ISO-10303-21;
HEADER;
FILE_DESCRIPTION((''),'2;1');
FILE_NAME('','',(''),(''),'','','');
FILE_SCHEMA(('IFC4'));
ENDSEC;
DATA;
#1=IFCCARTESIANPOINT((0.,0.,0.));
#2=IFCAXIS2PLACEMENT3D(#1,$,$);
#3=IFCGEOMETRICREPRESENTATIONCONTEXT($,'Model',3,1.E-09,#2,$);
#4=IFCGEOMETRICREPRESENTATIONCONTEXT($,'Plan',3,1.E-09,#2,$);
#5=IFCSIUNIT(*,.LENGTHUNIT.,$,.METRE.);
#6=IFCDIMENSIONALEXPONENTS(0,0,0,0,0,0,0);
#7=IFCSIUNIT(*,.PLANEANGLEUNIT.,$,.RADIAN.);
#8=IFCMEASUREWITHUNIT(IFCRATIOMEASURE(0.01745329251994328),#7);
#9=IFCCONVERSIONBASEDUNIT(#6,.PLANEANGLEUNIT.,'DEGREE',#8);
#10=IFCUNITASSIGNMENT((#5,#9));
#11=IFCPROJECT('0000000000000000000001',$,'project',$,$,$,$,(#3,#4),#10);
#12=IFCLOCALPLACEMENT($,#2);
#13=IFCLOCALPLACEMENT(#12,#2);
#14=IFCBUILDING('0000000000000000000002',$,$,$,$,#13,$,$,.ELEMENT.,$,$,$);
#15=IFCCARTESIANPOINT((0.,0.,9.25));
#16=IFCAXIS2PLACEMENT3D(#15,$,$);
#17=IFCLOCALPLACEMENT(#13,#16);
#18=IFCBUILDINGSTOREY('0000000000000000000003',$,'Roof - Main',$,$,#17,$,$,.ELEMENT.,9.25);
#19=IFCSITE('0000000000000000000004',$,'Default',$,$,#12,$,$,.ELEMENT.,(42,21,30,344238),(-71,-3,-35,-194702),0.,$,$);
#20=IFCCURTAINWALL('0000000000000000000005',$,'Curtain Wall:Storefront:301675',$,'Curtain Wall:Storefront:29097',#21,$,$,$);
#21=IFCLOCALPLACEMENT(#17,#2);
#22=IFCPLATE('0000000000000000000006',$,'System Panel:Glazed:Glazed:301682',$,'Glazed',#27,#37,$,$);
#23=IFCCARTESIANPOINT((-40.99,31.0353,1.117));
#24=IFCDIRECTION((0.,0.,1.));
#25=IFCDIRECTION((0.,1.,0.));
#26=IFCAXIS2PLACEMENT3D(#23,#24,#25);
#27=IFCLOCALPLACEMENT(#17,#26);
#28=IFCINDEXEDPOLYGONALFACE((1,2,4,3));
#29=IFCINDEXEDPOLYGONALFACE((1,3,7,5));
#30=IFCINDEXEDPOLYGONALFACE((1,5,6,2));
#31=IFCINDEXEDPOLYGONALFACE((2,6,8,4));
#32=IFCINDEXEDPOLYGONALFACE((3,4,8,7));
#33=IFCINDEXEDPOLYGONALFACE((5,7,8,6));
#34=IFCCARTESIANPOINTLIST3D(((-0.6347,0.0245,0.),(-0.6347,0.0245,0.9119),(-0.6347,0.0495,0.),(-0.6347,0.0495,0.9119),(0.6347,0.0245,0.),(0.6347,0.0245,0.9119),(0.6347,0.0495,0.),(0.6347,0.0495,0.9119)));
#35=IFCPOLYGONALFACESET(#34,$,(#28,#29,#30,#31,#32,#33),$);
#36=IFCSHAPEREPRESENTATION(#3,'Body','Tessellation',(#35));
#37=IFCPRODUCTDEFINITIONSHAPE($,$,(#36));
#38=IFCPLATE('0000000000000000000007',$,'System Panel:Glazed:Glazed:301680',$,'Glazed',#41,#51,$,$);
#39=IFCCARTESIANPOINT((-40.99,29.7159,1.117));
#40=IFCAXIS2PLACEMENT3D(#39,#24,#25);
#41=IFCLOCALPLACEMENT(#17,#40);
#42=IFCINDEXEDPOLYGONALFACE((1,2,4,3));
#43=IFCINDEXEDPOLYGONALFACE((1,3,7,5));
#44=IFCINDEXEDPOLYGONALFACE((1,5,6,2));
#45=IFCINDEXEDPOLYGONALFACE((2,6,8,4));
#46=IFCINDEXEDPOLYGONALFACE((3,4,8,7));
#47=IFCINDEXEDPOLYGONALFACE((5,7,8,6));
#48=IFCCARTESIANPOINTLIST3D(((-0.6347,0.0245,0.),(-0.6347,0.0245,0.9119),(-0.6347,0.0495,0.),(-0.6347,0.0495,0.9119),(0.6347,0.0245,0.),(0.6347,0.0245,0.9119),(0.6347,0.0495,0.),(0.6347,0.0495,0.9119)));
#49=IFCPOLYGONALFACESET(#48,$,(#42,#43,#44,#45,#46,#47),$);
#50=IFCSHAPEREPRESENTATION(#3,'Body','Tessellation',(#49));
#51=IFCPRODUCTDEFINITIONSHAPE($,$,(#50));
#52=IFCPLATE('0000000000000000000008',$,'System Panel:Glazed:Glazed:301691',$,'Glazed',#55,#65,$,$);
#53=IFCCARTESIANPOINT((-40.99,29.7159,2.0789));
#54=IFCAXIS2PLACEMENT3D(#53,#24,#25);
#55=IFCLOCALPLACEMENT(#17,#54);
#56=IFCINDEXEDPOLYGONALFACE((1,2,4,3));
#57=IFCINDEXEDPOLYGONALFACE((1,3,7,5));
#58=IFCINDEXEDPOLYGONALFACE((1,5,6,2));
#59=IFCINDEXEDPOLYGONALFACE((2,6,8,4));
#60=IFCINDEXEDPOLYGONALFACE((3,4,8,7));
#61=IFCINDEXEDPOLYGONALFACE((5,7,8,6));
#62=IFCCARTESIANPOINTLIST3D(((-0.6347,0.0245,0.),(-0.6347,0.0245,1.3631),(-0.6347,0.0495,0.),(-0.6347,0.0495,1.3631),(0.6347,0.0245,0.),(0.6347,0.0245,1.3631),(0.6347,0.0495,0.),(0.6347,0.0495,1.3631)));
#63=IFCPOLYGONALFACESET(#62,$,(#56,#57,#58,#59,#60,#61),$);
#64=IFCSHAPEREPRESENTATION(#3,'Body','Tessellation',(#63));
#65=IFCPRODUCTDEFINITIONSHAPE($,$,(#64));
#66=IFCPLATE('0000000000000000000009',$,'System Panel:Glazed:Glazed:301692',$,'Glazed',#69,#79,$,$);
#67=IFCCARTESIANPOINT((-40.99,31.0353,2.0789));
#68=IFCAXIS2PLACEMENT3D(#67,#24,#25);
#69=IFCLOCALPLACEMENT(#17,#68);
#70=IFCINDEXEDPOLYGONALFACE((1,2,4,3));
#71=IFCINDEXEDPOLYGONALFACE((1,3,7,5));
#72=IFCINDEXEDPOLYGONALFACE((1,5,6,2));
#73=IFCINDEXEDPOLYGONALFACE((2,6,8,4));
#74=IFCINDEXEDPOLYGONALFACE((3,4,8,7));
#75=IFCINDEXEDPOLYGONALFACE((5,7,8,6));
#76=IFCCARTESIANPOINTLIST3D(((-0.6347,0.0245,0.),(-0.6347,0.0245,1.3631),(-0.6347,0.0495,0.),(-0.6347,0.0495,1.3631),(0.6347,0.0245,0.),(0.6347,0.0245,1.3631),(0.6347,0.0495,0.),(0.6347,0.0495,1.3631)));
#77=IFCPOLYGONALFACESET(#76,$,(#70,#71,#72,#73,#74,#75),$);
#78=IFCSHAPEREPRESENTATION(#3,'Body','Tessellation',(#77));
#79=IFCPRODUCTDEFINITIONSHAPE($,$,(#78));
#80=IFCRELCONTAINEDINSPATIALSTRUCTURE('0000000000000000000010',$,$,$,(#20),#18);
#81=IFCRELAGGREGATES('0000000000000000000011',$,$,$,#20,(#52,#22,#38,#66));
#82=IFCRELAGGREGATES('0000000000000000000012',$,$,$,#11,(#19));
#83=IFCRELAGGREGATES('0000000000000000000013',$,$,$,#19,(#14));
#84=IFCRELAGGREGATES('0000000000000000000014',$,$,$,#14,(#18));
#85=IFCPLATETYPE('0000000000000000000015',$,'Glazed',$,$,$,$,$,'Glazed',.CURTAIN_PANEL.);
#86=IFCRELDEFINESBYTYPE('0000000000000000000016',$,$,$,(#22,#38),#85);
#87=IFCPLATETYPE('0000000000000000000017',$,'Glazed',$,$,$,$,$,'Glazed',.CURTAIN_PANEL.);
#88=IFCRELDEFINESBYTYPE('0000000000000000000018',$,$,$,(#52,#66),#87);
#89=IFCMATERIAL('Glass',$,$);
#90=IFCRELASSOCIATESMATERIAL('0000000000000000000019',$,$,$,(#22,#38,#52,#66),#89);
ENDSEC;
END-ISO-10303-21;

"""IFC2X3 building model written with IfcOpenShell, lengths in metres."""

from ifc_helpers import new_model, entity, si_unit, converted_unit, frame, origin, origin_2d_with_axis, place, context, project, spatial, rectangle, extrude, source, transform, mapped, material, type_object, type_shapes, element, aggregate, save


model = new_model("IFC2X3")

# Units and contexts
model_context = context("Model", 3, precision=1e-09, world=origin())
plan_context = context("Plan", 3, precision=1e-09, world=origin())
ifc_project = project(units=[si_unit("LENGTHUNIT", "METRE"), converted_unit("PLANEANGLEUNIT", "DEGREE", entity("IfcRatioMeasure", 0.01745329251994328), si_unit("PLANEANGLEUNIT", "RADIAN"), dimensions=[0, 0, 0, 0, 0, 0, 0])], contexts=[model_context, plan_context])

# Site, building, storey
site_placement = place(None, origin())
site = spatial("IfcSite", under=ifc_project, at=site_placement, Name="Default", CompositionType="ELEMENT", RefLatitude=(42, 21, 30, 344238), RefLongitude=(-71, -3, -35, -194702), RefElevation=0.0)
building_placement = place(site_placement, origin())
building = spatial("IfcBuilding", under=site, at=building_placement, CompositionType="ELEMENT")
storey_placement = place(building_placement, frame((0.0, 0.0, 9.25)))
storey = spatial("IfcBuildingStorey", under=building, at=storey_placement, Name="Roof - Main", CompositionType="ELEMENT", Elevation=9.25)

# Curtain wall, plates
curtain_wall_placement = place(storey_placement, origin())
curtain_wall = element("IfcCurtainWall", 1, at=curtain_wall_placement, inside=storey, Name="Curtain Wall:Storefront:301675", ObjectType="Curtain Wall:Storefront:29097")
ifc_material_1 = material(Name="Glass")
plate_type_1 = type_object("IfcPlateType", Name="Glazed", ElementType="Glazed", PredefinedType="CURTAIN_PANEL")
shared_shape_1 = source(origin(), model_context, "Body", "SweptSolid", [
    extrude(rectangle(XDim=0.025, YDim=1.2694, at=origin_2d_with_axis()), frame((0.0, 0.037, 0.0), z_axis=(0.0, 0.0, 1.0), x_axis=(0.0, 1.0, 0.0)), (0.0, 0.0, 1.0), 0.9119),
])
type_shapes(plate_type_1, [shared_shape_1])
plate_1_placement = place(storey_placement, frame((-40.99, 31.0353, 1.117), z_axis=(0.0, 0.0, 1.0), x_axis=(0.0, 1.0, 0.0)))
plate_1 = element("IfcPlate", 2, at=plate_1_placement, type_object=plate_type_1, material=ifc_material_1, Name="System Panel:Glazed:Glazed:301682", ObjectType="Glazed", context=model_context, shape_type="MappedRepresentation", body=[
    mapped(shared_shape_1, transform((0.0, 0.0, 0.0), scale=1.0)),
])
plate_2_placement = place(storey_placement, frame((-40.99, 29.7159, 1.117), z_axis=(0.0, 0.0, 1.0), x_axis=(0.0, 1.0, 0.0)))
plate_2 = element("IfcPlate", 3, at=plate_2_placement, type_object=plate_type_1, material=ifc_material_1, Name="System Panel:Glazed:Glazed:301680", ObjectType="Glazed", context=model_context, shape_type="MappedRepresentation", body=[
    mapped(shared_shape_1, transform((0.0, 0.0, 0.0), scale=1.0)),
])
plate_type_2 = type_object("IfcPlateType", Name="Glazed", ElementType="Glazed", PredefinedType="CURTAIN_PANEL")
shared_shape_2 = source(origin(), model_context, "Body", "SweptSolid", [
    extrude(rectangle(XDim=0.025, YDim=1.2694, at=origin_2d_with_axis()), frame((0.0, 0.037, 0.0), z_axis=(0.0, 0.0, 1.0), x_axis=(0.0, 1.0, 0.0)), (0.0, 0.0, 1.0), 1.3631),
])
type_shapes(plate_type_2, [shared_shape_2])
plate_3_placement = place(storey_placement, frame((-40.99, 29.7159, 2.0789), z_axis=(0.0, 0.0, 1.0), x_axis=(0.0, 1.0, 0.0)))
plate_3 = element("IfcPlate", 4, at=plate_3_placement, type_object=plate_type_2, material=ifc_material_1, Name="System Panel:Glazed:Glazed:301691", ObjectType="Glazed", context=model_context, shape_type="MappedRepresentation", body=[
    mapped(shared_shape_2, transform((0.0, 0.0, 0.0), scale=1.0)),
])
plate_4_placement = place(storey_placement, frame((-40.99, 31.0353, 2.0789), z_axis=(0.0, 0.0, 1.0), x_axis=(0.0, 1.0, 0.0)))
plate_4 = element("IfcPlate", 5, at=plate_4_placement, type_object=plate_type_2, material=ifc_material_1, Name="System Panel:Glazed:Glazed:301692", ObjectType="Glazed", context=model_context, shape_type="MappedRepresentation", body=[
    mapped(shared_shape_2, transform((0.0, 0.0, 0.0), scale=1.0)),
])
aggregate(curtain_wall, [plate_3, plate_1, plate_2, plate_4])

save(model, "model.ifc")
